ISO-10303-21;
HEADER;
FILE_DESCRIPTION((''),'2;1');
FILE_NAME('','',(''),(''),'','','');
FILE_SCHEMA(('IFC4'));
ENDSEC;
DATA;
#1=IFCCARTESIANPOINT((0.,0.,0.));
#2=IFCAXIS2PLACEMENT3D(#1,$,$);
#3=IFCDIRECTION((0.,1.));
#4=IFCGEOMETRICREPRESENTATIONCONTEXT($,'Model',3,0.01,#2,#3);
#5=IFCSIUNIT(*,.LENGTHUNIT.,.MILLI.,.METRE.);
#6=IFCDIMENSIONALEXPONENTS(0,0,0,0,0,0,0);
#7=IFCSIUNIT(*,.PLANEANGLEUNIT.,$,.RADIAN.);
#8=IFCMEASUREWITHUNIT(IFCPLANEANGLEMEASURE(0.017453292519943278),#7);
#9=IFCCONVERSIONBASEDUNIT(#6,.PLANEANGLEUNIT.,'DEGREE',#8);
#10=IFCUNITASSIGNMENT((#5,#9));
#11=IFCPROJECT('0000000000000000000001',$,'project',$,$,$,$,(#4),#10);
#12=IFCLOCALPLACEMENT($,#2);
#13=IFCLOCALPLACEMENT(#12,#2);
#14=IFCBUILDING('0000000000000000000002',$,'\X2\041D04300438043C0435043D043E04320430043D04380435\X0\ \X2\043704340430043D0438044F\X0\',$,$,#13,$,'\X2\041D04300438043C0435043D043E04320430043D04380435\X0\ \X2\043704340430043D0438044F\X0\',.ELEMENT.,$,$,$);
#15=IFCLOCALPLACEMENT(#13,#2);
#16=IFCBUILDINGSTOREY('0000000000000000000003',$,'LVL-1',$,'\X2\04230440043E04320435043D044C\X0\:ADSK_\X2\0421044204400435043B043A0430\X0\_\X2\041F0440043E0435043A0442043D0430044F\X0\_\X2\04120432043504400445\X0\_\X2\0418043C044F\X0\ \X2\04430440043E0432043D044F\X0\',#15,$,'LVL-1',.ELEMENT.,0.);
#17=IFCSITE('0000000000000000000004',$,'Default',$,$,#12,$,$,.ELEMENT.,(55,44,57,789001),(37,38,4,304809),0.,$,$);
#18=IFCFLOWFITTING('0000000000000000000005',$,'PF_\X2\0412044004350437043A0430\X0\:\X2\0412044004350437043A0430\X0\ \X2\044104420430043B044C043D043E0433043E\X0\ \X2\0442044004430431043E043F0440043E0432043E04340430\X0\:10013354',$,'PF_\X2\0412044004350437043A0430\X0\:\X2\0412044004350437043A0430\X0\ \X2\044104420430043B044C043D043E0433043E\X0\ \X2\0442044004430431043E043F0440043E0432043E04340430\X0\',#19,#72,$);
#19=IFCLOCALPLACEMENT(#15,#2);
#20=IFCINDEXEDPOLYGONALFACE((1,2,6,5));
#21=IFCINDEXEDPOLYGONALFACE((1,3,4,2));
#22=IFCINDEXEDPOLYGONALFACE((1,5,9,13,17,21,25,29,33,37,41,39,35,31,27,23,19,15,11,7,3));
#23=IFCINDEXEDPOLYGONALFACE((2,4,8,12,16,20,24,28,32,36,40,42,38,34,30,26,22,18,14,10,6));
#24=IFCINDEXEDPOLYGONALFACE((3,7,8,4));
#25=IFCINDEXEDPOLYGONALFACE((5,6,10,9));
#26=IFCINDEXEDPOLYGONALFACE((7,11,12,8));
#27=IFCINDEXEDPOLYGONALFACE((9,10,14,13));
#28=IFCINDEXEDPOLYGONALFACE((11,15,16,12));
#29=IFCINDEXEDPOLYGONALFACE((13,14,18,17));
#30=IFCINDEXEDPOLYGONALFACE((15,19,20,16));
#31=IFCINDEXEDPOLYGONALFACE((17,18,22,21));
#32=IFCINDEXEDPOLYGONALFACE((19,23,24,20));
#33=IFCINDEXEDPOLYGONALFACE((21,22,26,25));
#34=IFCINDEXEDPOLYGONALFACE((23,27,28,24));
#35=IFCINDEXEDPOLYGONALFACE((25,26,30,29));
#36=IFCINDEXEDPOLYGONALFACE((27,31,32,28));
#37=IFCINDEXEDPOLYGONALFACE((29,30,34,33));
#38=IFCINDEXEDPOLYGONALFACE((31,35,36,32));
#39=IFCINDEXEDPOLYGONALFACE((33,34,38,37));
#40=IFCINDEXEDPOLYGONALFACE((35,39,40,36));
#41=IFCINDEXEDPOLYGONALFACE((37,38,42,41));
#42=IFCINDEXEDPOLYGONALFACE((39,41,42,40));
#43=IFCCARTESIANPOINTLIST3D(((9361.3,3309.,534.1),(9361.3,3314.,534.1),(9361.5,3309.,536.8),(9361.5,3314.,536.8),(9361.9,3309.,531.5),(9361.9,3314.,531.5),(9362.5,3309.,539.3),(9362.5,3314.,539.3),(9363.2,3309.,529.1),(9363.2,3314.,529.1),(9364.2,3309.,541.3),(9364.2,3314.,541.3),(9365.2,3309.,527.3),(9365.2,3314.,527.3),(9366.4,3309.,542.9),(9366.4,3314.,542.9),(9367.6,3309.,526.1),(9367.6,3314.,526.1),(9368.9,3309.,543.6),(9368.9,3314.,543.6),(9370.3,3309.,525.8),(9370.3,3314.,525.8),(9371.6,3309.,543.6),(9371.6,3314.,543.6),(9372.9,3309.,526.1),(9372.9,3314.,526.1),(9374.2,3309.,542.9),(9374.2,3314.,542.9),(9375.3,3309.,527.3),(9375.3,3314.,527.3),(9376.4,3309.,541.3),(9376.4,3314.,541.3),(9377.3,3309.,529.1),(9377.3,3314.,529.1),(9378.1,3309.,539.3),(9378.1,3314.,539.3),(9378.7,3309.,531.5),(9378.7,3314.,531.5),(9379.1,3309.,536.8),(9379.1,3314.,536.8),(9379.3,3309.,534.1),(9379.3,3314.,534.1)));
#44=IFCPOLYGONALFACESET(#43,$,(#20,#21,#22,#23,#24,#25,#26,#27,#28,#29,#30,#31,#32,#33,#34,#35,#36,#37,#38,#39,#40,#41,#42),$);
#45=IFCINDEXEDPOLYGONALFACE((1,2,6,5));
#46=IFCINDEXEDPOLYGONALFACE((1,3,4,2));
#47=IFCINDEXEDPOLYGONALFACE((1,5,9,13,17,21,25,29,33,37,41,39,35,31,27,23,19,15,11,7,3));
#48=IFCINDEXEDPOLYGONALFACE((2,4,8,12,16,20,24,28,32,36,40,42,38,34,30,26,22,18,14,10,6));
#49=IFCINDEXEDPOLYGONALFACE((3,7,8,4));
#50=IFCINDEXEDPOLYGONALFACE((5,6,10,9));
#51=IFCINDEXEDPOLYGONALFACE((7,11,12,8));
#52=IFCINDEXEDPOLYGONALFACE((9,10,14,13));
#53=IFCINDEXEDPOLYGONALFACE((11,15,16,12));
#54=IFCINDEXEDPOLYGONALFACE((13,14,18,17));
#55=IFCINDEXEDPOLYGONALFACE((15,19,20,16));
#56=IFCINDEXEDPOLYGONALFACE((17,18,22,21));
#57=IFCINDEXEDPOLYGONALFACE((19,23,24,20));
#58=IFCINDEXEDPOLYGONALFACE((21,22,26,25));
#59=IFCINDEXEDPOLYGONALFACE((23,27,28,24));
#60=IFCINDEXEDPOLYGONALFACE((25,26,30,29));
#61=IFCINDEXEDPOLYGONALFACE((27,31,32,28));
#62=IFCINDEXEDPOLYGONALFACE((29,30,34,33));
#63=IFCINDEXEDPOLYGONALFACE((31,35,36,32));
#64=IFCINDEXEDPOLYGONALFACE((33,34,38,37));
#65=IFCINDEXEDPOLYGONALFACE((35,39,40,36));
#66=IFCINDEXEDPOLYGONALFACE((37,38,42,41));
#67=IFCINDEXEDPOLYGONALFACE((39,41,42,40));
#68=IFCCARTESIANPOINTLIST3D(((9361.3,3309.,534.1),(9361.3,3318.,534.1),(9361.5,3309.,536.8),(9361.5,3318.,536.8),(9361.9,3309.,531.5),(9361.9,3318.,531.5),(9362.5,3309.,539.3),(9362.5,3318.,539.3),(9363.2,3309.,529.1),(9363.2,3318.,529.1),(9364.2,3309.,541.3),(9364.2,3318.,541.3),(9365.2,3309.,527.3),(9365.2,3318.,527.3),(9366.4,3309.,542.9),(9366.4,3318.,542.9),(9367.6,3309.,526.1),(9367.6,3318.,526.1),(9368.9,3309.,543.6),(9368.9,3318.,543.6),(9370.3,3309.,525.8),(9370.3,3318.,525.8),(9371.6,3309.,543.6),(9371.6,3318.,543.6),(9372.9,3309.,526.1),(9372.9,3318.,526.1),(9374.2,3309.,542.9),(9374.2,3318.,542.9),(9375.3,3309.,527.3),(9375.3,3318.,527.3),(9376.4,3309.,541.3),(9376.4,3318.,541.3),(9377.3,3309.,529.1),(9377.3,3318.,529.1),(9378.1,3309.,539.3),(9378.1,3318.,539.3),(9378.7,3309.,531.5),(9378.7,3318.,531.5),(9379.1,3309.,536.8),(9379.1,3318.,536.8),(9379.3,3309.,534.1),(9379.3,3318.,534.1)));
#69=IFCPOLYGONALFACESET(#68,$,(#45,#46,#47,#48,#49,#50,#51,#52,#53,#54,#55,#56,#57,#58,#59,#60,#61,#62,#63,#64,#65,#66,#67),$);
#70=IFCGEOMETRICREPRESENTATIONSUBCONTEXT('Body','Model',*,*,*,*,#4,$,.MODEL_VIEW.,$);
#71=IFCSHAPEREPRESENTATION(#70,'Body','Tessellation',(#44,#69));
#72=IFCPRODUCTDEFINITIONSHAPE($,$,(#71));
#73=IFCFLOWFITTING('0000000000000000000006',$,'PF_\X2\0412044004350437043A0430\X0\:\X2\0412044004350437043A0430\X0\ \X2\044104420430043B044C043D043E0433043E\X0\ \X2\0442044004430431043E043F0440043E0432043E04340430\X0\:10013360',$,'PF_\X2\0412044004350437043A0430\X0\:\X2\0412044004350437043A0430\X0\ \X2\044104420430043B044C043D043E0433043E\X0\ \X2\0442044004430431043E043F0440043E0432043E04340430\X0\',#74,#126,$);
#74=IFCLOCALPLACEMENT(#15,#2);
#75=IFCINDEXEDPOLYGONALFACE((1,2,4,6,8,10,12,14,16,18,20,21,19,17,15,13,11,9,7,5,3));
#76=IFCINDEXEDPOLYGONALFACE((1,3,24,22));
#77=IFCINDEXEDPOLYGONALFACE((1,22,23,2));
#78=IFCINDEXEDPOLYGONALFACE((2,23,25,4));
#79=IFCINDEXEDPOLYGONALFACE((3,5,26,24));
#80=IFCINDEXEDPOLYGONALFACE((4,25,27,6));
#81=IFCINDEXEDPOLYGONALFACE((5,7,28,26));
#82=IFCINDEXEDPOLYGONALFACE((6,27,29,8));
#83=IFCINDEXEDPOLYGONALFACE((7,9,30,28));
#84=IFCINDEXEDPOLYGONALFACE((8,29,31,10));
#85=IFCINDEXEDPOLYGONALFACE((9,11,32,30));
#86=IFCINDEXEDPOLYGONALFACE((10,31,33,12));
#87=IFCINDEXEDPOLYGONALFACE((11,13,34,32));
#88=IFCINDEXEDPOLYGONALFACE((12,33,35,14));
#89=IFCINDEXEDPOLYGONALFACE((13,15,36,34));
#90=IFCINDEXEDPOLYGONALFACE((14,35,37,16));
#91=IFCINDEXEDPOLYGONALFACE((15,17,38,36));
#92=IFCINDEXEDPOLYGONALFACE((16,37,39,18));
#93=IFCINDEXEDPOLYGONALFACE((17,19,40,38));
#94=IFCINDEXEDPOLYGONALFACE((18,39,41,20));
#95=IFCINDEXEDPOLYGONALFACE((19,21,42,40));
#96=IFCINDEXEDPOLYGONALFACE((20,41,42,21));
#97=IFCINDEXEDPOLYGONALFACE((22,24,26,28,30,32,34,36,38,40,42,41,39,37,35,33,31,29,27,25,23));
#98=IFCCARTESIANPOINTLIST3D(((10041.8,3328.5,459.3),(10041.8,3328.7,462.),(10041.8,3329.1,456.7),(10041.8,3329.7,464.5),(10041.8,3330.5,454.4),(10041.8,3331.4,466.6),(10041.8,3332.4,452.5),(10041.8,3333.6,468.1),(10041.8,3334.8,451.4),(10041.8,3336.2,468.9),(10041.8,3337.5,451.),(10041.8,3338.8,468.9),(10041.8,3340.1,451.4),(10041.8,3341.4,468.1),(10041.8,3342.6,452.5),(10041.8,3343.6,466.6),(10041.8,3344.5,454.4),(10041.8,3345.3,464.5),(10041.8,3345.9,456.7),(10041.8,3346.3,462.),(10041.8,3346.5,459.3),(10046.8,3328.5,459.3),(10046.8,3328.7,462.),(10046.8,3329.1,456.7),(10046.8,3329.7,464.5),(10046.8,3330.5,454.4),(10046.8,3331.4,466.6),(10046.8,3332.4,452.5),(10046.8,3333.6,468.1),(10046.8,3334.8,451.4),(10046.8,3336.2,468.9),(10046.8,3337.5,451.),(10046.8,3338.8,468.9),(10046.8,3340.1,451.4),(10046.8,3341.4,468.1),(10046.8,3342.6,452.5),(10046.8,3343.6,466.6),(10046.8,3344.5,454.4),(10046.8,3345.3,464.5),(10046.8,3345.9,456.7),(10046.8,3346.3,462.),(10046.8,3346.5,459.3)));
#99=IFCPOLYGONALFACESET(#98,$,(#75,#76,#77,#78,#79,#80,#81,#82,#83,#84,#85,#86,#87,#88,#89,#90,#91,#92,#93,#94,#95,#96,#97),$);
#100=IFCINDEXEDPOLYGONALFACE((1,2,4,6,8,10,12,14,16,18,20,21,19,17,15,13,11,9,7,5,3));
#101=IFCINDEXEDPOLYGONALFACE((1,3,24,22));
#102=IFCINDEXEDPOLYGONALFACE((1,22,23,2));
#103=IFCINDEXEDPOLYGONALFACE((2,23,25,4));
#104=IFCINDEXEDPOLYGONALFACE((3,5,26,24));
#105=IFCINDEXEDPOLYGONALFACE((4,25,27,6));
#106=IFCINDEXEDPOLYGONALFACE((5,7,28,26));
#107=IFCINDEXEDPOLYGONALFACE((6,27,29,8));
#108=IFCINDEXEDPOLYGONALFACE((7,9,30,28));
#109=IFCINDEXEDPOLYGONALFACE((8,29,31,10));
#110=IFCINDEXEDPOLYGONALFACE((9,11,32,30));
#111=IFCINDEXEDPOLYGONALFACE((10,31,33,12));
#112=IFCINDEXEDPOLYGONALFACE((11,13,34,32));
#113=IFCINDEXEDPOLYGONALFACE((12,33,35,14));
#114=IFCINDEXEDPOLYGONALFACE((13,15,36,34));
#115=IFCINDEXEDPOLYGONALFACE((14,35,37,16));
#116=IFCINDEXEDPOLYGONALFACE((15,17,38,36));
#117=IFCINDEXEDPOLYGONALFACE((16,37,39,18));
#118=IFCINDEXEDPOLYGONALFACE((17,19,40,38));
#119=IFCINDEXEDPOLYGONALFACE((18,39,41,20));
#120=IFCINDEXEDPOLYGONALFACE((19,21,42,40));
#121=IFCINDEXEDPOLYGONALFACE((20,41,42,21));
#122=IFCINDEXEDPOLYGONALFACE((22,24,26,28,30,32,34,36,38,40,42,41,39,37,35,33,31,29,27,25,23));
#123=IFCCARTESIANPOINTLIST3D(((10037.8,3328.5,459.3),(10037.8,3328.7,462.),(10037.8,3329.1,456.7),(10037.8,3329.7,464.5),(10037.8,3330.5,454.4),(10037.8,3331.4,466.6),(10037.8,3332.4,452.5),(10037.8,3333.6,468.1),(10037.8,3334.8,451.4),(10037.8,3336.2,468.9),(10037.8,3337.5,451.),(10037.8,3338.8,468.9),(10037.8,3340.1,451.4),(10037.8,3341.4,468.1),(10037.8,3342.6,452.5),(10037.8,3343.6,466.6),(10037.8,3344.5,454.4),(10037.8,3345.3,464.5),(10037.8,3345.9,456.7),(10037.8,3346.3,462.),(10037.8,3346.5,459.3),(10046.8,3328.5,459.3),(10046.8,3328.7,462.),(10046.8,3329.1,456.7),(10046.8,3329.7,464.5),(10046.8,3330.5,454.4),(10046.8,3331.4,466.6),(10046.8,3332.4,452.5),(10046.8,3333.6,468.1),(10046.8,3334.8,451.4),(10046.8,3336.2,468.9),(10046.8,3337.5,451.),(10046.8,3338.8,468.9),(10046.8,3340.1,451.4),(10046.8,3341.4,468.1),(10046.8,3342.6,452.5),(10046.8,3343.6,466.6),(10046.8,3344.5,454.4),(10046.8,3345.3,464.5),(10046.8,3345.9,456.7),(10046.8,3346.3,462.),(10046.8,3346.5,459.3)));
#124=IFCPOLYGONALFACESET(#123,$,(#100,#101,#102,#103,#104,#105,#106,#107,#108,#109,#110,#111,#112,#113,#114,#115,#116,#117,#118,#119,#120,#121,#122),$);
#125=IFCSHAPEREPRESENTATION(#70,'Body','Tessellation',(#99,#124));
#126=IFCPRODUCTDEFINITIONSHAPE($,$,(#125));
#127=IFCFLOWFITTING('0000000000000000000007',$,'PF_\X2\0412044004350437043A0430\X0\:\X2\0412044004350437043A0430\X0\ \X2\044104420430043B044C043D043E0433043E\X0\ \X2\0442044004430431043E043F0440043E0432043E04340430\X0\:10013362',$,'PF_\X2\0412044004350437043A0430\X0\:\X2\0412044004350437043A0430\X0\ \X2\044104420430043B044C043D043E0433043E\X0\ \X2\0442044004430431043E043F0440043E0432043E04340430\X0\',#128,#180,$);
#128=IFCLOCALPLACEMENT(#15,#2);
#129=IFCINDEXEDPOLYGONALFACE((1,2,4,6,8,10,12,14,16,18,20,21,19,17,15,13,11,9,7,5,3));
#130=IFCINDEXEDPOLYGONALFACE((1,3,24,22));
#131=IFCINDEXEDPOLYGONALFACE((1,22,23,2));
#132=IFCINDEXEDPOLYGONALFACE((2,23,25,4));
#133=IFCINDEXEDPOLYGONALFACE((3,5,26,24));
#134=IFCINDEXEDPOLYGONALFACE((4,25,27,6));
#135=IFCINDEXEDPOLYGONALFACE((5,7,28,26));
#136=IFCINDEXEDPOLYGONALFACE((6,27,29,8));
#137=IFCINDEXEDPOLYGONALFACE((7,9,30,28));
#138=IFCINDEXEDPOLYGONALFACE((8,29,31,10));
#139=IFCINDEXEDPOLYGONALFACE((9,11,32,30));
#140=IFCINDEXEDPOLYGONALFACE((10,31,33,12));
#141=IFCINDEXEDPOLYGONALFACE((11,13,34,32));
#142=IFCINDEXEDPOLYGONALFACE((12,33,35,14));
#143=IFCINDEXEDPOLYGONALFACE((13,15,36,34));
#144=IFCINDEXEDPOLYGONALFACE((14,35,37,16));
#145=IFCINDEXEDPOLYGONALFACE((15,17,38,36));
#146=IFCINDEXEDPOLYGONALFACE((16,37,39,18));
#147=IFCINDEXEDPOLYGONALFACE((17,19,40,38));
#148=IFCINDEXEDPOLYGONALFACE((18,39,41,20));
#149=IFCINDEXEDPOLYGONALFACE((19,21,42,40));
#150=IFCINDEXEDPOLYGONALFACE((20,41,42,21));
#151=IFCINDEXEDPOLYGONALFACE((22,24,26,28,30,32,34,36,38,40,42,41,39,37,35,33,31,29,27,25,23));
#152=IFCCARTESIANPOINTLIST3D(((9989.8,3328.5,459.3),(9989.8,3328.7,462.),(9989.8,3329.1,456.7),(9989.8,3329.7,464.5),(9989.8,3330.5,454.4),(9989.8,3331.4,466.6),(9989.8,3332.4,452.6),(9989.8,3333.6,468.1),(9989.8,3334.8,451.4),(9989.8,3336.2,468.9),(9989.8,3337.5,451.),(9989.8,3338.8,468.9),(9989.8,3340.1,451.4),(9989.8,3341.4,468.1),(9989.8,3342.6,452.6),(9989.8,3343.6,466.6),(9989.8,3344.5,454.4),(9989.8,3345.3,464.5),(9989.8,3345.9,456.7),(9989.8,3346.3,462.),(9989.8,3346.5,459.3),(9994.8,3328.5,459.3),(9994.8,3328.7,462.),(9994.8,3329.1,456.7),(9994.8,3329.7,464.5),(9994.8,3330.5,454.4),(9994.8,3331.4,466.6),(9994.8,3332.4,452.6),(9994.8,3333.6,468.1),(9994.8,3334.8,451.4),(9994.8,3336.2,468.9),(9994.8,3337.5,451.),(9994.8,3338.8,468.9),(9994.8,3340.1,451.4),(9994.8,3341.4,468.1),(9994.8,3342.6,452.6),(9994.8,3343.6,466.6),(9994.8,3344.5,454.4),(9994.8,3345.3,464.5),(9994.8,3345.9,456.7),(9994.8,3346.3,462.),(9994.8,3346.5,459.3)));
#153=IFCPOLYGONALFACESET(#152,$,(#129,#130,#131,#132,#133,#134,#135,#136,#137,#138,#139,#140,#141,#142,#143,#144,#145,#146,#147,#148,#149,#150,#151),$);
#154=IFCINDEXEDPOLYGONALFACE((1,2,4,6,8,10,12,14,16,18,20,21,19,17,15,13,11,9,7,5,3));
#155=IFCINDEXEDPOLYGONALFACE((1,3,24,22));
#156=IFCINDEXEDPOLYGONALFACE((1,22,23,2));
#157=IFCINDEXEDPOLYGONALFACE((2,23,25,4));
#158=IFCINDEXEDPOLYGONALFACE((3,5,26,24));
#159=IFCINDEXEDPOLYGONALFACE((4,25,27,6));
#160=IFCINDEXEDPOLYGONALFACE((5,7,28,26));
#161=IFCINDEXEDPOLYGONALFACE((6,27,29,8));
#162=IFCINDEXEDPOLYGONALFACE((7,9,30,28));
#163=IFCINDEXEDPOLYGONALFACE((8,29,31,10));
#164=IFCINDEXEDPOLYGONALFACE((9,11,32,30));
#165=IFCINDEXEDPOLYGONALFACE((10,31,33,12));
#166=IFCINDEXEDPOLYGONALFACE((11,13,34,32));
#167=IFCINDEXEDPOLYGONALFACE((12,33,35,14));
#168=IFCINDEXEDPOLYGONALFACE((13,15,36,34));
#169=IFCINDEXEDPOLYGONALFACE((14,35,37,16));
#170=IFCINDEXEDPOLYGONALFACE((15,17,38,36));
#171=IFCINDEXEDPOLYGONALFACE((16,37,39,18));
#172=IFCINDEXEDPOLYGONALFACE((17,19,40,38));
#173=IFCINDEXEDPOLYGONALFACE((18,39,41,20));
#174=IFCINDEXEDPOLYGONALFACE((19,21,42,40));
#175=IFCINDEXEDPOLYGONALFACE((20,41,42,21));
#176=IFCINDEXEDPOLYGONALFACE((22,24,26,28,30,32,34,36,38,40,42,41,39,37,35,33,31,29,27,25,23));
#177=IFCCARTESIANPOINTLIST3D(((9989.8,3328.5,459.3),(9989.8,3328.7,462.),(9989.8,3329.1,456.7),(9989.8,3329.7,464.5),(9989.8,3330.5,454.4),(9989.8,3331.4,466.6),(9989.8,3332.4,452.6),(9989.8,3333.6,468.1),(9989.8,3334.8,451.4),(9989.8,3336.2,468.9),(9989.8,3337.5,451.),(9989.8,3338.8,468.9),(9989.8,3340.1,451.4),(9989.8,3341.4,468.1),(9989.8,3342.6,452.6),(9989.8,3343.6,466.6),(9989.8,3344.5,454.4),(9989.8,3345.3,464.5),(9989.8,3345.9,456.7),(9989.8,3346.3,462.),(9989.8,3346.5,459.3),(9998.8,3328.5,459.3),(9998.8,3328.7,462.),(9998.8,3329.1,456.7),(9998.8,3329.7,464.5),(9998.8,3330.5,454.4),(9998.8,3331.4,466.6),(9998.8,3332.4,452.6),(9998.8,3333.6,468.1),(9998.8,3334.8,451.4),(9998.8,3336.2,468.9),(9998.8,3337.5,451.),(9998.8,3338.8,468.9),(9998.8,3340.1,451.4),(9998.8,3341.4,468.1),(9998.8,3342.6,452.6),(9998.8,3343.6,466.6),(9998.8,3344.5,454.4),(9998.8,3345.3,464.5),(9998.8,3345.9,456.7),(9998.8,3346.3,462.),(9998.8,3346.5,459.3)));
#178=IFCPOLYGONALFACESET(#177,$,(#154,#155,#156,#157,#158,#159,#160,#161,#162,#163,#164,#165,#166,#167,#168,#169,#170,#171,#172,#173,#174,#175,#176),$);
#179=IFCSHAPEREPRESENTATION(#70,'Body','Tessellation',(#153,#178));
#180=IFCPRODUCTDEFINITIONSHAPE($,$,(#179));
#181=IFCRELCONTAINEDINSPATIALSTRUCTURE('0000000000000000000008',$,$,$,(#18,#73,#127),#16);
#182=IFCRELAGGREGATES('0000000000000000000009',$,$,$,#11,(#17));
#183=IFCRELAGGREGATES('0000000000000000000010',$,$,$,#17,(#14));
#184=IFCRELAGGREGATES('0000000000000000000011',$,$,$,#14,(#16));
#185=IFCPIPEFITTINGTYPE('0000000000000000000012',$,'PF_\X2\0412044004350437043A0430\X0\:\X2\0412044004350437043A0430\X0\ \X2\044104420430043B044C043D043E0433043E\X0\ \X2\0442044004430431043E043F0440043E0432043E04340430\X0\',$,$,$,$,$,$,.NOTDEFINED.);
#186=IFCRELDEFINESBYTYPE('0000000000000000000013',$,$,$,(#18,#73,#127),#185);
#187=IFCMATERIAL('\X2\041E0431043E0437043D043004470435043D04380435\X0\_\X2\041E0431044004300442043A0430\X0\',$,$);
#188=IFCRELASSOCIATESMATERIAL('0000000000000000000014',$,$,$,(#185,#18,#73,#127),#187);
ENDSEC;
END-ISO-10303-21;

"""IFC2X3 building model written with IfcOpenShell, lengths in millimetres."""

from ifc_helpers import new_model, entity, si_unit, converted_unit, direction, frame, frame_2d, origin, place, context, subcontext, project, spatial, circle, extrude, source, transform, mapped, material, type_object, type_shapes, element, save


model = new_model("IFC2X3")

# Units and contexts
model_context = context("Model", 3, precision=0.01, world=origin(), true_north=direction((0.0, 1.0)))
body_context = subcontext(model_context, "Body", "Model", "MODEL_VIEW")
ifc_project = project(units=[si_unit("LENGTHUNIT", "METRE", prefix="MILLI"), converted_unit("PLANEANGLEUNIT", "DEGREE", entity("IfcPlaneAngleMeasure", 0.017453292519943278), si_unit("PLANEANGLEUNIT", "RADIAN"), dimensions=[0, 0, 0, 0, 0, 0, 0])], contexts=[model_context])

# Site, building, storey
site_placement = place(None, origin())
site = spatial("IfcSite", under=ifc_project, at=site_placement, Name="Default", CompositionType="ELEMENT", RefLatitude=(55, 44, 57, 789001), RefLongitude=(37, 38, 4, 304809), RefElevation=0.0)
building_placement = place(site_placement, origin())
building = spatial("IfcBuilding", under=site, at=building_placement, Name="Наименование здания", LongName="Наименование здания", CompositionType="ELEMENT")
storey_placement = place(building_placement, origin())
storey = spatial("IfcBuildingStorey", under=building, at=storey_placement, Name="LVL-1", ObjectType="Уровень:ADSK_Стрелка_Проектная_Вверх_Имя уровня", LongName="LVL-1", CompositionType="ELEMENT", Elevation=0.0)

# Flow fittings
ifc_material_1 = material(Name="Обозначение_Обратка")
pipe_fitting_type_1 = type_object("IfcPipeFittingType", Name="PF_Врезка:Врезка стального трубопровода", PredefinedType="NOTDEFINED", material=ifc_material_1)
shared_shape_1 = source(origin(), body_context, "Body", "SweptSolid", [
    extrude(circle(Radius=9.0, at=frame_2d((0.0, 0.0), x_axis=(1.0, 0.0))), frame((-5.0, 0.0, 0.0), z_axis=(1.0, 0.0, 0.0), x_axis=(0.0, -1.0, 0.0)), (0.0, 0.0, 1.0), 5.0),
    extrude(circle(Radius=9.0, at=frame_2d((0.0, 0.0), x_axis=(1.0, 0.0))), frame((-9.0, 0.0, 0.0), z_axis=(1.0, 0.0, 0.0), x_axis=(0.0, -1.0, 0.0)), (0.0, 0.0, 1.0), 9.0),
])
type_shapes(pipe_fitting_type_1, [shared_shape_1])
for number, where, z_axis, x_axis, name in (
    (1, (9370.3, 3309.0, 534.8), (-1.0, 0.0, 0.0), (0.0, -1.0, 0.0), "PF_Врезка:Врезка стального трубопровода:10013354"),
    (2, (10046.8, 3337.5, 460.0), (0.0, -1.0, 0.0), (1.0, 0.0, 0.0), "PF_Врезка:Врезка стального трубопровода:10013360"),
    (3, (9989.8, 3337.5, 460.0), (0.0, 1.0, 0.0), (-1.0, 0.0, 0.0), "PF_Врезка:Врезка стального трубопровода:10013362"),
):
    element("IfcFlowFitting", number, at=place(storey_placement, frame(where, z_axis=z_axis, x_axis=x_axis)), inside=storey, type_object=pipe_fitting_type_1, material=ifc_material_1, Name=name, ObjectType="PF_Врезка:Врезка стального трубопровода", context=body_context, shape_type="MappedRepresentation", body=[
        mapped(shared_shape_1, transform((0.0, 0.0, 0.0), scale=1.0)),
    ])

save(model, "model.ifc")
